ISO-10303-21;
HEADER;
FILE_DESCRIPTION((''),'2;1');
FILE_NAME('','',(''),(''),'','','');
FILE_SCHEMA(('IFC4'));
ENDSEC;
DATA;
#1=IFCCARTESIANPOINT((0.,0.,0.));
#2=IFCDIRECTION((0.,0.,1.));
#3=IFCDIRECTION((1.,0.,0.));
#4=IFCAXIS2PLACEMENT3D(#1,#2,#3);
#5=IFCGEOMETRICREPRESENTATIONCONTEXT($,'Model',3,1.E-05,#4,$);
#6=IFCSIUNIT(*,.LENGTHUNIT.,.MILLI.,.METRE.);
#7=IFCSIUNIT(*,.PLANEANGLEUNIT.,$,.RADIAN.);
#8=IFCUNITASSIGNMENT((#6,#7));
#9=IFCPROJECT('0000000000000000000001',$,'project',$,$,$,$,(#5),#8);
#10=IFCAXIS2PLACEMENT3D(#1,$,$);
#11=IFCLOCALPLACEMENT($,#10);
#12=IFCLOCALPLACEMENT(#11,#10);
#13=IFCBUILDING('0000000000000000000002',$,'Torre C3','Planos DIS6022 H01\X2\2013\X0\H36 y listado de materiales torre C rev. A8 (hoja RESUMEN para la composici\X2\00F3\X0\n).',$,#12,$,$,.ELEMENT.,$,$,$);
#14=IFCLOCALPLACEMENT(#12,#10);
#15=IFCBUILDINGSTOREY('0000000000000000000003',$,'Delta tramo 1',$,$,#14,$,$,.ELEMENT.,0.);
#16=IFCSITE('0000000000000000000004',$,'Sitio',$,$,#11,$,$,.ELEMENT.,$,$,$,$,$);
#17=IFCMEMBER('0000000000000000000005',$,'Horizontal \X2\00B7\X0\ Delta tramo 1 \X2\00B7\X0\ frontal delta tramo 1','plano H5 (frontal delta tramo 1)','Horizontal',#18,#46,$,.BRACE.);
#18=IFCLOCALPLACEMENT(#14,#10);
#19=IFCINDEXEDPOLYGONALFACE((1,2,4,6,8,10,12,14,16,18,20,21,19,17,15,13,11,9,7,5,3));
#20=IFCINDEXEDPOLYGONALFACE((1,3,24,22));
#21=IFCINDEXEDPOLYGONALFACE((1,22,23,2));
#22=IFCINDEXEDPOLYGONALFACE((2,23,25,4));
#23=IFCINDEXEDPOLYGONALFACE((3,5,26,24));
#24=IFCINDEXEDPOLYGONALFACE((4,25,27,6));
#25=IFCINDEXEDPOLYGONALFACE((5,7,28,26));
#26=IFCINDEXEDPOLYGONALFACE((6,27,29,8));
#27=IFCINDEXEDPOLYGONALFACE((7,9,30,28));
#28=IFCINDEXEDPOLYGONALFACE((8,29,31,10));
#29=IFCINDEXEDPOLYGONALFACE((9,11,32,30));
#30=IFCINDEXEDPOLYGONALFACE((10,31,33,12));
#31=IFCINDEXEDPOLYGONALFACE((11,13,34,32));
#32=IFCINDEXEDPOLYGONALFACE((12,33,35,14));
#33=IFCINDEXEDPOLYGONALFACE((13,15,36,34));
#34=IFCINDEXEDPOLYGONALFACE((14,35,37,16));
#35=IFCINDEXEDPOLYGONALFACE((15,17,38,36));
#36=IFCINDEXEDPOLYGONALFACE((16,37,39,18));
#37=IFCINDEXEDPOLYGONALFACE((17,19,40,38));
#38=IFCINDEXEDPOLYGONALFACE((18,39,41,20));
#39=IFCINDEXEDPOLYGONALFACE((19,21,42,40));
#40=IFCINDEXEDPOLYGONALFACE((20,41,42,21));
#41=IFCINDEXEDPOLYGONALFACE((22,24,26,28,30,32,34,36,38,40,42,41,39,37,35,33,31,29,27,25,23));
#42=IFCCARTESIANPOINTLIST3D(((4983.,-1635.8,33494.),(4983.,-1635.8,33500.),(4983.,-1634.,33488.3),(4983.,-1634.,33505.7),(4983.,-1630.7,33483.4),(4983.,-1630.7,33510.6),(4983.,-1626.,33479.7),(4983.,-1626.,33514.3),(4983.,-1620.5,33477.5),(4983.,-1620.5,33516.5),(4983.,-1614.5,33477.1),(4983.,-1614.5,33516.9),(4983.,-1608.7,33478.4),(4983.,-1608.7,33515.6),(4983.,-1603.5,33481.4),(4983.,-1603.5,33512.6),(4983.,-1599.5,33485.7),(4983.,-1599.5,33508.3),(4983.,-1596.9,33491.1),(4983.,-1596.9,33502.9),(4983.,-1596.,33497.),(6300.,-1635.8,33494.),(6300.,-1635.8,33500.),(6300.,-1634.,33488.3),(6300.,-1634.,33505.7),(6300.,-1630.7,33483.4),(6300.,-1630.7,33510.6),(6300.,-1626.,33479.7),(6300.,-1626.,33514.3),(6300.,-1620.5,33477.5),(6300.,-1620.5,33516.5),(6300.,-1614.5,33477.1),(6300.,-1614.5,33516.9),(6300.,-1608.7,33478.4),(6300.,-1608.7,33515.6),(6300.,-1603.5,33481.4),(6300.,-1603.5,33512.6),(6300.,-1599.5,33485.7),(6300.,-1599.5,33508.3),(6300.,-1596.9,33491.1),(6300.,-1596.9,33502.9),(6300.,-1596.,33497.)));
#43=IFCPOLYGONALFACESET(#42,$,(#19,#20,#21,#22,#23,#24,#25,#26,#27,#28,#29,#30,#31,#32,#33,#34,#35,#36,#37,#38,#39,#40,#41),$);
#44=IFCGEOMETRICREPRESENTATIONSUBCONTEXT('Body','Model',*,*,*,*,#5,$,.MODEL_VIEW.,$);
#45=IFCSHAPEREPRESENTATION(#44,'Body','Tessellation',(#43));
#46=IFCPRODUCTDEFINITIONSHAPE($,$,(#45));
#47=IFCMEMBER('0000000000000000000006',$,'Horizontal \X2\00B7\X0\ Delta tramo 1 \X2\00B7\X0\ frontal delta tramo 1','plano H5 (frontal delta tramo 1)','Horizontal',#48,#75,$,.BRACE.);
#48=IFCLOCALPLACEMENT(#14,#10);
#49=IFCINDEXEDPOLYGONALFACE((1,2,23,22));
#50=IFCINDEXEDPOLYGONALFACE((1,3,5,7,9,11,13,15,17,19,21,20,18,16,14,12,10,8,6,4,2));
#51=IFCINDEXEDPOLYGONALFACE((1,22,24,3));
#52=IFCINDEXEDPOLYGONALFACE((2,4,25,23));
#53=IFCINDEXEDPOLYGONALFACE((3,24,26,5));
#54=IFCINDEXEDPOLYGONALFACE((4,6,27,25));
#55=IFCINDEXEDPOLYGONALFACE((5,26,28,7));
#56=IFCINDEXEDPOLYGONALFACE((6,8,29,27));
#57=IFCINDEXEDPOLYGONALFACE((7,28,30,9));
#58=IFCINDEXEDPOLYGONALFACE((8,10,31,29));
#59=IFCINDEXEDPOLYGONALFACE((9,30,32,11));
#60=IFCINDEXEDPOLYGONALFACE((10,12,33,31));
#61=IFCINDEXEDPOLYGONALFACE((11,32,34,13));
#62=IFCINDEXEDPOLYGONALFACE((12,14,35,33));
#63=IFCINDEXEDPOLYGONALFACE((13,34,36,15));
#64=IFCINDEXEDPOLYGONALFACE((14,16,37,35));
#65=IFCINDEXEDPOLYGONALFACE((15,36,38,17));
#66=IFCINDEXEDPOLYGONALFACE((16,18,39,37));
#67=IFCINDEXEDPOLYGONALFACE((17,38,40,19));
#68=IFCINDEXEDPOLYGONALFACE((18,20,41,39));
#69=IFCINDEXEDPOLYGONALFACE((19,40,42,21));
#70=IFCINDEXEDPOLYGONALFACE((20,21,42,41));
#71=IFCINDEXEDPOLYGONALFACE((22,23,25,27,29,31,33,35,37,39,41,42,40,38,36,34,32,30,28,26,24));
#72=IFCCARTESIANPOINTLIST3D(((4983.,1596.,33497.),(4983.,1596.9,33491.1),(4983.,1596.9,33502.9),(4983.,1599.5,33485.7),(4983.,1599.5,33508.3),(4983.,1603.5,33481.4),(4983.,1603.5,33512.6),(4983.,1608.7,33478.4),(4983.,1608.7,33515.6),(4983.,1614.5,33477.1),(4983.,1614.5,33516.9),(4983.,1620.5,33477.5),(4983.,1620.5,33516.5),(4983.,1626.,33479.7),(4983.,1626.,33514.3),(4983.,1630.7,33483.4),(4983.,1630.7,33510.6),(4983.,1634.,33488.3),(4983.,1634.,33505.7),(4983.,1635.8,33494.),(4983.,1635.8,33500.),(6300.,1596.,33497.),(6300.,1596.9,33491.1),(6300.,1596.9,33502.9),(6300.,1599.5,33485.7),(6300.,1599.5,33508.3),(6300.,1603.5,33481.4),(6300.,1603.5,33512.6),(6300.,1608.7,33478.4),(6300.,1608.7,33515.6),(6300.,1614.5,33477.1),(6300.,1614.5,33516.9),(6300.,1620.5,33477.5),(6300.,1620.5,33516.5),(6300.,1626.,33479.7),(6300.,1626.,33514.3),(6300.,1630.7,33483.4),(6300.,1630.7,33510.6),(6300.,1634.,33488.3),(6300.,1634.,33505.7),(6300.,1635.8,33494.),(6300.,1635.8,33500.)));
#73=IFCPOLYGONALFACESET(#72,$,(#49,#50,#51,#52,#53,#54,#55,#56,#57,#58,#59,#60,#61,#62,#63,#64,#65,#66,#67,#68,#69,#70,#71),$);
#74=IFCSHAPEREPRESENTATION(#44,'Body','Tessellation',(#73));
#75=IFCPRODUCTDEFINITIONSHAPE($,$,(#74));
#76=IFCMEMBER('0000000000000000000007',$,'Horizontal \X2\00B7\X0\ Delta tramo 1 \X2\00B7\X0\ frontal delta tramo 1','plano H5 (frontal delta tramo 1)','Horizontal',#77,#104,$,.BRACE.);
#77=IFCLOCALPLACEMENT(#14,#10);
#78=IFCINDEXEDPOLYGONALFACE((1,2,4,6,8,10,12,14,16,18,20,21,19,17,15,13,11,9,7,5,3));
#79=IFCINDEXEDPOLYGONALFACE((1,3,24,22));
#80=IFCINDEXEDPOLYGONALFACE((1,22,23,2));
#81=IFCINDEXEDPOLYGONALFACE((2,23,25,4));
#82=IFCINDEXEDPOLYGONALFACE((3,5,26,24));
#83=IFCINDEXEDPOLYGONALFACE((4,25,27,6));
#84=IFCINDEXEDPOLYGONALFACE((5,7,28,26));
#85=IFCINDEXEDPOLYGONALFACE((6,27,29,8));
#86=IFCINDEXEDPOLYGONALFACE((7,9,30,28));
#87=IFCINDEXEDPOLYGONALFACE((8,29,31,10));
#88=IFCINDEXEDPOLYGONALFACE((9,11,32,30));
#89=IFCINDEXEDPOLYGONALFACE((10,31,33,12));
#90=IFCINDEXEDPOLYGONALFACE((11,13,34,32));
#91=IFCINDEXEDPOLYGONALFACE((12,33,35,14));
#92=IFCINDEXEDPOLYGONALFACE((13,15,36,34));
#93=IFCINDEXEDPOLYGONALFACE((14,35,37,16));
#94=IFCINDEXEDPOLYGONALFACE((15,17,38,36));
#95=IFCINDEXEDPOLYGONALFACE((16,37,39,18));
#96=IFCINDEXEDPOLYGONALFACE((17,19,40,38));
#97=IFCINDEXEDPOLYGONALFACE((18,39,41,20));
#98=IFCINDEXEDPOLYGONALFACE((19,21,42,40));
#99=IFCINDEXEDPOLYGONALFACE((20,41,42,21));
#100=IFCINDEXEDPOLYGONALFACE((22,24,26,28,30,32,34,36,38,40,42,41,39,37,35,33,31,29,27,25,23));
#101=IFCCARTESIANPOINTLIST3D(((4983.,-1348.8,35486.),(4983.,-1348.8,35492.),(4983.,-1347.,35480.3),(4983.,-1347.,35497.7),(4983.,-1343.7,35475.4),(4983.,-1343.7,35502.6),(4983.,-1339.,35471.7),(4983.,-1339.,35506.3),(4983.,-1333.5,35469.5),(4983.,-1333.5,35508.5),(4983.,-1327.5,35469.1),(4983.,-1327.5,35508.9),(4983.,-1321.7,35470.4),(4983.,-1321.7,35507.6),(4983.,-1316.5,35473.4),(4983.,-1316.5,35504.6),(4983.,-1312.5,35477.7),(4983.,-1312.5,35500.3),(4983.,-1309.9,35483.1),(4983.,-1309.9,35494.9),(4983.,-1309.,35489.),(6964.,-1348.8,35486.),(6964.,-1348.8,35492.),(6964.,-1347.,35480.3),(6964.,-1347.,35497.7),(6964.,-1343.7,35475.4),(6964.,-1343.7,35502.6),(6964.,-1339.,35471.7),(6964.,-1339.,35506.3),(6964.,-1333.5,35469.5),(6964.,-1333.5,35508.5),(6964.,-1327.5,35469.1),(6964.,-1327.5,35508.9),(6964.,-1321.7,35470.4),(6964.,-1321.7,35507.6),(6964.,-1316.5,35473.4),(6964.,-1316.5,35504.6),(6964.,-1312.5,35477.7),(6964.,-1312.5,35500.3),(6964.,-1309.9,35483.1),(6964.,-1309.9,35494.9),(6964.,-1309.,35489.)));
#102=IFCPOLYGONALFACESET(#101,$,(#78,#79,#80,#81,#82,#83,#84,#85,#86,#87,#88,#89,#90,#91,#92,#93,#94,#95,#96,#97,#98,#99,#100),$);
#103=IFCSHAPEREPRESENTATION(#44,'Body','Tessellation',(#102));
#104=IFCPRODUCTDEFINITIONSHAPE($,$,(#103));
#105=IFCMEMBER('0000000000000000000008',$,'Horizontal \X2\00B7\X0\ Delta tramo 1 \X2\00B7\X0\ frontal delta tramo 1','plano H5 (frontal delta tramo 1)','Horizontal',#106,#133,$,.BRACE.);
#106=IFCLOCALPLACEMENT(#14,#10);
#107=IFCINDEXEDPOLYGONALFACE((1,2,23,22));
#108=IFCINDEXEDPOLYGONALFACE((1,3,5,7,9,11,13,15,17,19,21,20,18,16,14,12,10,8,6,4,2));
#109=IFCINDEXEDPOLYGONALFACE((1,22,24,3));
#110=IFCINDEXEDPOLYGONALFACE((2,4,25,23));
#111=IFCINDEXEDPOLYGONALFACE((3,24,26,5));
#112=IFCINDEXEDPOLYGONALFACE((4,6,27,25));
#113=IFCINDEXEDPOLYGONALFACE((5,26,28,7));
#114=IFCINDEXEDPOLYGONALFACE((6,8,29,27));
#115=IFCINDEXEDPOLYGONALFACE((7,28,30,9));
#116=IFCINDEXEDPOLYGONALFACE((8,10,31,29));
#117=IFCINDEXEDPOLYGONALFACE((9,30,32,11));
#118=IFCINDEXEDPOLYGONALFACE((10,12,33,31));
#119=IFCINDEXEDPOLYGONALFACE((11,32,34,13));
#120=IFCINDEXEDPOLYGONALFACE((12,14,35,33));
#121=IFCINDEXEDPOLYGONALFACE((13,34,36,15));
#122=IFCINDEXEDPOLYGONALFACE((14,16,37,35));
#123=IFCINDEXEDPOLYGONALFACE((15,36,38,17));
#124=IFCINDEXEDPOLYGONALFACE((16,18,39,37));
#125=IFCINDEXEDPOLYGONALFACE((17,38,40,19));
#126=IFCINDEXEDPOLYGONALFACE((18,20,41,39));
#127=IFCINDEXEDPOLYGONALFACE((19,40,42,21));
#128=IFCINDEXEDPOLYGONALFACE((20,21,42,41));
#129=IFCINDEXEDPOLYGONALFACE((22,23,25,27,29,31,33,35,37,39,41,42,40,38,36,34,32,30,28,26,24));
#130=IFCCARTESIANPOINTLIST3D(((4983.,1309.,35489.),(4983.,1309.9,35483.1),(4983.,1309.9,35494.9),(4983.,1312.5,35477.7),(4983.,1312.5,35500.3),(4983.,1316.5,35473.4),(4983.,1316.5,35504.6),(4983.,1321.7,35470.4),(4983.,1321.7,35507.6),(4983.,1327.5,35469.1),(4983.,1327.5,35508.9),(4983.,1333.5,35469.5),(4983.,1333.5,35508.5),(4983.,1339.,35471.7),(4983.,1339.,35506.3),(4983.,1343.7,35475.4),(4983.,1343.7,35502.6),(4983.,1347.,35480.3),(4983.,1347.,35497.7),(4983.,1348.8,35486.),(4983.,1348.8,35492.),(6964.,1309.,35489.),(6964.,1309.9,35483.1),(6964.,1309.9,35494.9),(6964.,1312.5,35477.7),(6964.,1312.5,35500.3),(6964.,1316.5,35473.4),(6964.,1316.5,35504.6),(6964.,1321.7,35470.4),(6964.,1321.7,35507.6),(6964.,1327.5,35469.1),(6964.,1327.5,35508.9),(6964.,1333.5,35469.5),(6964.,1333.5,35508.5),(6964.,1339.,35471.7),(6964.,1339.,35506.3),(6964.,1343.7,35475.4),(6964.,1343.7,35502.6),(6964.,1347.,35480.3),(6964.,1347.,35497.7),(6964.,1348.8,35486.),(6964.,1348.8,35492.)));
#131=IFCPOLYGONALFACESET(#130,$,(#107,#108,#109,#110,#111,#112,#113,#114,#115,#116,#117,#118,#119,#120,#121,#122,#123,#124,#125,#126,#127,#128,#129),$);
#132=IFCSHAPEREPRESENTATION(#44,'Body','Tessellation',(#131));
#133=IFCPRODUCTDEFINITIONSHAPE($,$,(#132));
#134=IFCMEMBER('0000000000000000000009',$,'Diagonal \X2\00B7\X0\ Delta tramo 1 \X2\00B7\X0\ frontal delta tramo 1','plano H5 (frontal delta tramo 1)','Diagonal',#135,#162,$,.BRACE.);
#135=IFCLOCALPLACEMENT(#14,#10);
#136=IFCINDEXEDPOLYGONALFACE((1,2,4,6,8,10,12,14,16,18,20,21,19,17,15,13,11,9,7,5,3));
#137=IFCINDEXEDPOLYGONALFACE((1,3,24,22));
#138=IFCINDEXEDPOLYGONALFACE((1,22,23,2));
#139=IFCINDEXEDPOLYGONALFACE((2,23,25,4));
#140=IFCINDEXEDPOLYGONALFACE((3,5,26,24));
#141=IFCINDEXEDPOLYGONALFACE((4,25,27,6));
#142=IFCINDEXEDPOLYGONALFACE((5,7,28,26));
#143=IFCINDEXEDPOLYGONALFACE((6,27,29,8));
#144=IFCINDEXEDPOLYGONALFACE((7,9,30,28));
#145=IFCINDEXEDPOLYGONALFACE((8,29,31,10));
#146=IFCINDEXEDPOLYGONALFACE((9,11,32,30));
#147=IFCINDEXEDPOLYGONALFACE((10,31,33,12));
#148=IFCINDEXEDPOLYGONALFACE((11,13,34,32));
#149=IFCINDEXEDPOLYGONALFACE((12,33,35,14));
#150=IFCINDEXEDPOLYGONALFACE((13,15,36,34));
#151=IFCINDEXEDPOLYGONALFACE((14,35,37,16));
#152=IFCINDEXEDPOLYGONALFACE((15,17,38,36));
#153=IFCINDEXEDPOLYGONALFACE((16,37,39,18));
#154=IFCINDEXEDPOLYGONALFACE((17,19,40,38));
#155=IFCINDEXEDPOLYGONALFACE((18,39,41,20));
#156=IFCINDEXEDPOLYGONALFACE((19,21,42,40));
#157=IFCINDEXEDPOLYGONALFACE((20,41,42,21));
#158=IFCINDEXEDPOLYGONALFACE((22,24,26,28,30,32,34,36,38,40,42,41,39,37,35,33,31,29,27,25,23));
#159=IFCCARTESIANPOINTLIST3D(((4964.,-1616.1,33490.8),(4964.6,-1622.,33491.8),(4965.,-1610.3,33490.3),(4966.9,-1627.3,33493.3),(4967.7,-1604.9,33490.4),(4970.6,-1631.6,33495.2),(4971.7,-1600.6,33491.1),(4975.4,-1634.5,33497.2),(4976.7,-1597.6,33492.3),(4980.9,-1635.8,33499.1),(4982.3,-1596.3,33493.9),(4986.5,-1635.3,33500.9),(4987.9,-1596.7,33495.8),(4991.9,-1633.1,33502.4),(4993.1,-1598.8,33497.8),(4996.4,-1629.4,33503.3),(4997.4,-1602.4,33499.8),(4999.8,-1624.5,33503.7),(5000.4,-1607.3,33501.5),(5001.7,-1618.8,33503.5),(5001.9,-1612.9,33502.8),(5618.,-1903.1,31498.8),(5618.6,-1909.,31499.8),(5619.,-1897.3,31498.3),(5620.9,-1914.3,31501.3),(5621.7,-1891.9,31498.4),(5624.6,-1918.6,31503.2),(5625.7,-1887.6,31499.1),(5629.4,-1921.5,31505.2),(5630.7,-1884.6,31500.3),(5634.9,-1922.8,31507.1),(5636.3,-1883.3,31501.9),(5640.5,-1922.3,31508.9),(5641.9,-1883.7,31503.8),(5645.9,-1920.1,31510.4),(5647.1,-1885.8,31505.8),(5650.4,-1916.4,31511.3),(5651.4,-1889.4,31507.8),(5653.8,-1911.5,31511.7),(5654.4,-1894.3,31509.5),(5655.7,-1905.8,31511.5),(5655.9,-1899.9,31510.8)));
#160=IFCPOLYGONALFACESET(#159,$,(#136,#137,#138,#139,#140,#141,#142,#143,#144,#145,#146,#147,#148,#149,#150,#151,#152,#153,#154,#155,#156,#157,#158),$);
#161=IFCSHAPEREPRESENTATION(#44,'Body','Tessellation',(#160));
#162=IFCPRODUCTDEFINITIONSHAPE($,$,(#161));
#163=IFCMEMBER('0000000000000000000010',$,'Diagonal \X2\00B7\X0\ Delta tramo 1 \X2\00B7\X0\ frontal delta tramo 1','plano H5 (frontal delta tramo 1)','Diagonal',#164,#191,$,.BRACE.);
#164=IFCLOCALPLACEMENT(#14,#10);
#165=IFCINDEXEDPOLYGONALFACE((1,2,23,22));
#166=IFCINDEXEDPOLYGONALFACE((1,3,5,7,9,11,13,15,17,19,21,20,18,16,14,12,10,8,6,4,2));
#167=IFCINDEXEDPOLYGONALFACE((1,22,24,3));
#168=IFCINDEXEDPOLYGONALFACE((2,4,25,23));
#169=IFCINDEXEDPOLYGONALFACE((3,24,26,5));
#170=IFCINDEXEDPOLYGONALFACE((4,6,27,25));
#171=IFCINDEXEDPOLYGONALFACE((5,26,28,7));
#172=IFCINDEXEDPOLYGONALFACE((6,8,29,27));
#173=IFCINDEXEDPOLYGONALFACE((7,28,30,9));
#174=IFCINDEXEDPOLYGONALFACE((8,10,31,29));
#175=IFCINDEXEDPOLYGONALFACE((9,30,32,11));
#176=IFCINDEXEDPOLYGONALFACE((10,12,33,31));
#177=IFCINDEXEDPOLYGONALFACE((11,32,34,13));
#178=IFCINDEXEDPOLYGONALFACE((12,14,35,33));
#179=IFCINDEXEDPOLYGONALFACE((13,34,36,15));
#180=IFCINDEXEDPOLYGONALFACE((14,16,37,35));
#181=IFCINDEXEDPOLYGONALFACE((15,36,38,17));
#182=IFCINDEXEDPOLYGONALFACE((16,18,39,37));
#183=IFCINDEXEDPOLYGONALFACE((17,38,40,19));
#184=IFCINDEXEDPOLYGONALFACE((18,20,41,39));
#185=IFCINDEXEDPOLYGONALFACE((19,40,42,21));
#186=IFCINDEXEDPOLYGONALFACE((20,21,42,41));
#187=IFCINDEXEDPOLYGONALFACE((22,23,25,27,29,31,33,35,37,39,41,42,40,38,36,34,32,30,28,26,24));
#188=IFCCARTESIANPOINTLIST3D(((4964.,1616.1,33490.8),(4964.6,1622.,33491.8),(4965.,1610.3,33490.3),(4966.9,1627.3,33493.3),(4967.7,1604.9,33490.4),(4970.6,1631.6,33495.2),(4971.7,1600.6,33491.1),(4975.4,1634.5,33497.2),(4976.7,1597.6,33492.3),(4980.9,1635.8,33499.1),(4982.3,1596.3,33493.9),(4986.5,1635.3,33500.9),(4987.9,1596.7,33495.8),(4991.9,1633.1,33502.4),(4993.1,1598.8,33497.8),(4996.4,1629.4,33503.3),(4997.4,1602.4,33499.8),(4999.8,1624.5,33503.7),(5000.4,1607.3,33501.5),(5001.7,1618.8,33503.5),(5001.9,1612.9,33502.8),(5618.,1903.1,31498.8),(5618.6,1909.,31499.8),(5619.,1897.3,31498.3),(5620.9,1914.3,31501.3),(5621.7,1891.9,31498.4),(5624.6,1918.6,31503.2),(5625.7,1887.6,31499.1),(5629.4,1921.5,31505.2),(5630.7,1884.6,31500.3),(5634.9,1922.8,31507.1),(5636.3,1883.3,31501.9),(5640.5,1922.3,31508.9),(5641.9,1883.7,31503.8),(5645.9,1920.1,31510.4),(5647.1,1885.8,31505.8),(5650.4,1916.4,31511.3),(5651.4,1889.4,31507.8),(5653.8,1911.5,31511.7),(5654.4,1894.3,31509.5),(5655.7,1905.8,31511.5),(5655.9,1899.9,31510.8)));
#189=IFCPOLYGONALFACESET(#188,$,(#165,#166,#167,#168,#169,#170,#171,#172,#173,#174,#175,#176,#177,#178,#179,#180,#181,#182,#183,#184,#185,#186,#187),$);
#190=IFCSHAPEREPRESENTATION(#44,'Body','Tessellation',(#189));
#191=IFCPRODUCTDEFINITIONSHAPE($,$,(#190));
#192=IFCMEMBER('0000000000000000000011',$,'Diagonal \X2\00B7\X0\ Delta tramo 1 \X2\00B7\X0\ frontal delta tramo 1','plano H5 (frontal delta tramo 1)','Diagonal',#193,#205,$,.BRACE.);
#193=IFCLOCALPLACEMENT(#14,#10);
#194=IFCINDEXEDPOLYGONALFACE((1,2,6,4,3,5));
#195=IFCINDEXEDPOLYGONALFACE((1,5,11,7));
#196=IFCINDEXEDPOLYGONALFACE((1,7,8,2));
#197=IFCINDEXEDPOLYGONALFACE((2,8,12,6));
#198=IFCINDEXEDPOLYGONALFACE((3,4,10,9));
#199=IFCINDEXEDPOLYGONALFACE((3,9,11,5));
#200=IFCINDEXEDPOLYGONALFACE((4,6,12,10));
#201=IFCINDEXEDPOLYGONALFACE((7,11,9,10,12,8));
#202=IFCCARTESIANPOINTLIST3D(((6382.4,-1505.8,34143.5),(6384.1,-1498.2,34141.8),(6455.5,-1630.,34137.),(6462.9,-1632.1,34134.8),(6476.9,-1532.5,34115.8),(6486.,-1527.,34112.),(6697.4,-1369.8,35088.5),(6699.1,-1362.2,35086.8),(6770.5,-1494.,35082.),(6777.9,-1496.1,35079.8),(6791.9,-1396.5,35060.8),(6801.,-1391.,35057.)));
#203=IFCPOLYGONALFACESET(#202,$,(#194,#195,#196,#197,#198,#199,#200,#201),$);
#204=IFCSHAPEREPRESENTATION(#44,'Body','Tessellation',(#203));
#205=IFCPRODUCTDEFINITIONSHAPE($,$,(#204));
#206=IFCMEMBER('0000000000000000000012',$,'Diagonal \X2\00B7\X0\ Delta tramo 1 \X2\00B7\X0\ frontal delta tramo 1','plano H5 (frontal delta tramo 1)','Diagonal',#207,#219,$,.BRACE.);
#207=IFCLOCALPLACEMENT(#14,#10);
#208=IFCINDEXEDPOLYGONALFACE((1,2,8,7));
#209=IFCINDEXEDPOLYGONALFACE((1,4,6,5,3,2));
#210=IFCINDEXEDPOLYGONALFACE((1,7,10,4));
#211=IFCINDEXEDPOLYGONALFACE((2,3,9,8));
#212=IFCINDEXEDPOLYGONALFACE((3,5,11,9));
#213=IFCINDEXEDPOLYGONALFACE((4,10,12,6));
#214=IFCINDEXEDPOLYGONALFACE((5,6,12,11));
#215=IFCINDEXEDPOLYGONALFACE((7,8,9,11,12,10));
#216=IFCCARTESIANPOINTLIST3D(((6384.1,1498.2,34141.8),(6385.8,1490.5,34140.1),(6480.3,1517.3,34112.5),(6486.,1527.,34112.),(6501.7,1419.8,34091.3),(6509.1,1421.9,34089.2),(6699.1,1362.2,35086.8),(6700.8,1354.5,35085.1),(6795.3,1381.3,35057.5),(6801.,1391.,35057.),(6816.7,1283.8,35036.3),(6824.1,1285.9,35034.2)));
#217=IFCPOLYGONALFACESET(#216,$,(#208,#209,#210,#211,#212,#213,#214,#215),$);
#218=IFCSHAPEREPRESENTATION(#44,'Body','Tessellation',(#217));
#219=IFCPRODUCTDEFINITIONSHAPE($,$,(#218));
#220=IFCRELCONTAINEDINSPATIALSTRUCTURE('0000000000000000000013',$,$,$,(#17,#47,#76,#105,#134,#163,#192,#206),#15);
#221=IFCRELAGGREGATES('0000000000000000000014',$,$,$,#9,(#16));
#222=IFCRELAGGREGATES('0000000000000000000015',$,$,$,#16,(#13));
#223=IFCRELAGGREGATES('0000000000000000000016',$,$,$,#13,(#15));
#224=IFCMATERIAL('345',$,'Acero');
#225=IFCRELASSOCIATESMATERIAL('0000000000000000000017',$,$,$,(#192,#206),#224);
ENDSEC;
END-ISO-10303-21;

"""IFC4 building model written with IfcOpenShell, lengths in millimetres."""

from ifc_helpers import new_model, si_unit, frame, frame_2d, origin, origin_with_axes, place, context, subcontext, project, spatial, circle, l_section, extrude, material, element, save


model = new_model("IFC4")

# Units and contexts
model_context = context("Model", 3, precision=1e-05, world=origin_with_axes())
body_context = subcontext(model_context, "Body", "Model", "MODEL_VIEW")
ifc_project = project(units=[si_unit("LENGTHUNIT", "METRE", prefix="MILLI"), si_unit("PLANEANGLEUNIT", "RADIAN")], contexts=[model_context])

# Site, building, storey
site_placement = place(None, origin())
site = spatial("IfcSite", under=ifc_project, at=site_placement, Name="Sitio", CompositionType="ELEMENT")
building_placement = place(site_placement, origin())
building = spatial("IfcBuilding", under=site, at=building_placement, Name="Torre C3", Description="Planos DIS6022 H01–H36 y listado de materiales torre C rev. A8 (hoja RESUMEN para la composición).", CompositionType="ELEMENT")
storey_placement = place(building_placement, origin())
storey = spatial("IfcBuildingStorey", under=building, at=storey_placement, Name="Delta tramo 1", CompositionType="ELEMENT", Elevation=0.0)

# Members
for number, where, z_axis, x_axis, name in (
    (1, (6300.0, -1616.0, 33497.0), (-1.0, 0.0, 0.0), (0.0, 1.0, 0.0), "Horizontal · Delta tramo 1 · frontal delta tramo 1"),
    (2, (6300.0, 1616.0, 33497.0), (-1.0, 0.0, 0.0), (0.0, -1.0, 0.0), "Horizontal · Delta tramo 1 · frontal delta tramo 1"),
):
    element("IfcMember", number, at=place(storey_placement, frame(where, z_axis=z_axis, x_axis=x_axis)), inside=storey, Name=name, Description="plano H5 (frontal delta tramo 1)", ObjectType="Horizontal", PredefinedType="BRACE", context=body_context, shape_type="SweptSolid", body=[
        extrude(circle(Radius=20.0), None, (0.0, 0.0, 1.0), 1317.0),
    ])
for number, where, z_axis, x_axis, name in (
    (3, (6964.0, -1329.0, 35489.0), (-1.0, 0.0, 0.0), (0.0, 1.0, 0.0), "Horizontal · Delta tramo 1 · frontal delta tramo 1"),
    (4, (6964.0, 1329.0, 35489.0), (-1.0, 0.0, 0.0), (0.0, -1.0, 0.0), "Horizontal · Delta tramo 1 · frontal delta tramo 1"),
):
    element("IfcMember", number, at=place(storey_placement, frame(where, z_axis=z_axis, x_axis=x_axis)), inside=storey, Name=name, Description="plano H5 (frontal delta tramo 1)", ObjectType="Horizontal", PredefinedType="BRACE", context=body_context, shape_type="SweptSolid", body=[
        extrude(circle(Radius=20.0), None, (0.0, 0.0, 1.0), 1981.0),
    ])
for number, where, z_axis, x_axis, name in (
    (5, (4983.0, -1616.0, 33497.0), (0.30905, -0.135623, -0.941326), (-0.897588, 0.28557, -0.335834), "Diagonal · Delta tramo 1 · frontal delta tramo 1"),
    (6, (4983.0, 1616.0, 33497.0), (0.30905, 0.135623, -0.941326), (-0.897588, -0.28557, -0.335834), "Diagonal · Delta tramo 1 · frontal delta tramo 1"),
):
    element("IfcMember", number, at=place(storey_placement, frame(where, z_axis=z_axis, x_axis=x_axis)), inside=storey, Name=name, Description="plano H5 (frontal delta tramo 1)", ObjectType="Diagonal", PredefinedType="BRACE", context=body_context, shape_type="SweptSolid", body=[
        extrude(circle(Radius=20.0), None, (0.0, 0.0, 1.0), 2116.2),
    ])
ifc_material_1 = material(Name="345", Category="Acero")
for number, where, z_axis, x_axis, name in (
    (7, (6486.0, -1527.0, 34112.0), (0.313321, 0.135275, 0.939963), (-0.926175, 0.262236, 0.270985), "Diagonal · Delta tramo 1 · frontal delta tramo 1"),
    (8, (6486.0, 1527.0, 34112.0), (0.313321, -0.135275, 0.939963), (-0.926175, -0.262236, 0.270985), "Diagonal · Delta tramo 1 · frontal delta tramo 1"),
):
    element("IfcMember", number, at=place(storey_placement, frame(where, z_axis=z_axis, x_axis=x_axis)), inside=storey, material=ifc_material_1, Name=name, Description="plano H5 (frontal delta tramo 1)", ObjectType="Diagonal", PredefinedType="BRACE", context=body_context, shape_type="SweptSolid", body=[
        extrude(l_section(Depth=110.0, Width=110.0, Thickness=8.0, at=frame_2d((55.0, 55.0))), None, (0.0, 0.0, 1.0), 1005.4),
    ])

save(model, "model.ifc")
